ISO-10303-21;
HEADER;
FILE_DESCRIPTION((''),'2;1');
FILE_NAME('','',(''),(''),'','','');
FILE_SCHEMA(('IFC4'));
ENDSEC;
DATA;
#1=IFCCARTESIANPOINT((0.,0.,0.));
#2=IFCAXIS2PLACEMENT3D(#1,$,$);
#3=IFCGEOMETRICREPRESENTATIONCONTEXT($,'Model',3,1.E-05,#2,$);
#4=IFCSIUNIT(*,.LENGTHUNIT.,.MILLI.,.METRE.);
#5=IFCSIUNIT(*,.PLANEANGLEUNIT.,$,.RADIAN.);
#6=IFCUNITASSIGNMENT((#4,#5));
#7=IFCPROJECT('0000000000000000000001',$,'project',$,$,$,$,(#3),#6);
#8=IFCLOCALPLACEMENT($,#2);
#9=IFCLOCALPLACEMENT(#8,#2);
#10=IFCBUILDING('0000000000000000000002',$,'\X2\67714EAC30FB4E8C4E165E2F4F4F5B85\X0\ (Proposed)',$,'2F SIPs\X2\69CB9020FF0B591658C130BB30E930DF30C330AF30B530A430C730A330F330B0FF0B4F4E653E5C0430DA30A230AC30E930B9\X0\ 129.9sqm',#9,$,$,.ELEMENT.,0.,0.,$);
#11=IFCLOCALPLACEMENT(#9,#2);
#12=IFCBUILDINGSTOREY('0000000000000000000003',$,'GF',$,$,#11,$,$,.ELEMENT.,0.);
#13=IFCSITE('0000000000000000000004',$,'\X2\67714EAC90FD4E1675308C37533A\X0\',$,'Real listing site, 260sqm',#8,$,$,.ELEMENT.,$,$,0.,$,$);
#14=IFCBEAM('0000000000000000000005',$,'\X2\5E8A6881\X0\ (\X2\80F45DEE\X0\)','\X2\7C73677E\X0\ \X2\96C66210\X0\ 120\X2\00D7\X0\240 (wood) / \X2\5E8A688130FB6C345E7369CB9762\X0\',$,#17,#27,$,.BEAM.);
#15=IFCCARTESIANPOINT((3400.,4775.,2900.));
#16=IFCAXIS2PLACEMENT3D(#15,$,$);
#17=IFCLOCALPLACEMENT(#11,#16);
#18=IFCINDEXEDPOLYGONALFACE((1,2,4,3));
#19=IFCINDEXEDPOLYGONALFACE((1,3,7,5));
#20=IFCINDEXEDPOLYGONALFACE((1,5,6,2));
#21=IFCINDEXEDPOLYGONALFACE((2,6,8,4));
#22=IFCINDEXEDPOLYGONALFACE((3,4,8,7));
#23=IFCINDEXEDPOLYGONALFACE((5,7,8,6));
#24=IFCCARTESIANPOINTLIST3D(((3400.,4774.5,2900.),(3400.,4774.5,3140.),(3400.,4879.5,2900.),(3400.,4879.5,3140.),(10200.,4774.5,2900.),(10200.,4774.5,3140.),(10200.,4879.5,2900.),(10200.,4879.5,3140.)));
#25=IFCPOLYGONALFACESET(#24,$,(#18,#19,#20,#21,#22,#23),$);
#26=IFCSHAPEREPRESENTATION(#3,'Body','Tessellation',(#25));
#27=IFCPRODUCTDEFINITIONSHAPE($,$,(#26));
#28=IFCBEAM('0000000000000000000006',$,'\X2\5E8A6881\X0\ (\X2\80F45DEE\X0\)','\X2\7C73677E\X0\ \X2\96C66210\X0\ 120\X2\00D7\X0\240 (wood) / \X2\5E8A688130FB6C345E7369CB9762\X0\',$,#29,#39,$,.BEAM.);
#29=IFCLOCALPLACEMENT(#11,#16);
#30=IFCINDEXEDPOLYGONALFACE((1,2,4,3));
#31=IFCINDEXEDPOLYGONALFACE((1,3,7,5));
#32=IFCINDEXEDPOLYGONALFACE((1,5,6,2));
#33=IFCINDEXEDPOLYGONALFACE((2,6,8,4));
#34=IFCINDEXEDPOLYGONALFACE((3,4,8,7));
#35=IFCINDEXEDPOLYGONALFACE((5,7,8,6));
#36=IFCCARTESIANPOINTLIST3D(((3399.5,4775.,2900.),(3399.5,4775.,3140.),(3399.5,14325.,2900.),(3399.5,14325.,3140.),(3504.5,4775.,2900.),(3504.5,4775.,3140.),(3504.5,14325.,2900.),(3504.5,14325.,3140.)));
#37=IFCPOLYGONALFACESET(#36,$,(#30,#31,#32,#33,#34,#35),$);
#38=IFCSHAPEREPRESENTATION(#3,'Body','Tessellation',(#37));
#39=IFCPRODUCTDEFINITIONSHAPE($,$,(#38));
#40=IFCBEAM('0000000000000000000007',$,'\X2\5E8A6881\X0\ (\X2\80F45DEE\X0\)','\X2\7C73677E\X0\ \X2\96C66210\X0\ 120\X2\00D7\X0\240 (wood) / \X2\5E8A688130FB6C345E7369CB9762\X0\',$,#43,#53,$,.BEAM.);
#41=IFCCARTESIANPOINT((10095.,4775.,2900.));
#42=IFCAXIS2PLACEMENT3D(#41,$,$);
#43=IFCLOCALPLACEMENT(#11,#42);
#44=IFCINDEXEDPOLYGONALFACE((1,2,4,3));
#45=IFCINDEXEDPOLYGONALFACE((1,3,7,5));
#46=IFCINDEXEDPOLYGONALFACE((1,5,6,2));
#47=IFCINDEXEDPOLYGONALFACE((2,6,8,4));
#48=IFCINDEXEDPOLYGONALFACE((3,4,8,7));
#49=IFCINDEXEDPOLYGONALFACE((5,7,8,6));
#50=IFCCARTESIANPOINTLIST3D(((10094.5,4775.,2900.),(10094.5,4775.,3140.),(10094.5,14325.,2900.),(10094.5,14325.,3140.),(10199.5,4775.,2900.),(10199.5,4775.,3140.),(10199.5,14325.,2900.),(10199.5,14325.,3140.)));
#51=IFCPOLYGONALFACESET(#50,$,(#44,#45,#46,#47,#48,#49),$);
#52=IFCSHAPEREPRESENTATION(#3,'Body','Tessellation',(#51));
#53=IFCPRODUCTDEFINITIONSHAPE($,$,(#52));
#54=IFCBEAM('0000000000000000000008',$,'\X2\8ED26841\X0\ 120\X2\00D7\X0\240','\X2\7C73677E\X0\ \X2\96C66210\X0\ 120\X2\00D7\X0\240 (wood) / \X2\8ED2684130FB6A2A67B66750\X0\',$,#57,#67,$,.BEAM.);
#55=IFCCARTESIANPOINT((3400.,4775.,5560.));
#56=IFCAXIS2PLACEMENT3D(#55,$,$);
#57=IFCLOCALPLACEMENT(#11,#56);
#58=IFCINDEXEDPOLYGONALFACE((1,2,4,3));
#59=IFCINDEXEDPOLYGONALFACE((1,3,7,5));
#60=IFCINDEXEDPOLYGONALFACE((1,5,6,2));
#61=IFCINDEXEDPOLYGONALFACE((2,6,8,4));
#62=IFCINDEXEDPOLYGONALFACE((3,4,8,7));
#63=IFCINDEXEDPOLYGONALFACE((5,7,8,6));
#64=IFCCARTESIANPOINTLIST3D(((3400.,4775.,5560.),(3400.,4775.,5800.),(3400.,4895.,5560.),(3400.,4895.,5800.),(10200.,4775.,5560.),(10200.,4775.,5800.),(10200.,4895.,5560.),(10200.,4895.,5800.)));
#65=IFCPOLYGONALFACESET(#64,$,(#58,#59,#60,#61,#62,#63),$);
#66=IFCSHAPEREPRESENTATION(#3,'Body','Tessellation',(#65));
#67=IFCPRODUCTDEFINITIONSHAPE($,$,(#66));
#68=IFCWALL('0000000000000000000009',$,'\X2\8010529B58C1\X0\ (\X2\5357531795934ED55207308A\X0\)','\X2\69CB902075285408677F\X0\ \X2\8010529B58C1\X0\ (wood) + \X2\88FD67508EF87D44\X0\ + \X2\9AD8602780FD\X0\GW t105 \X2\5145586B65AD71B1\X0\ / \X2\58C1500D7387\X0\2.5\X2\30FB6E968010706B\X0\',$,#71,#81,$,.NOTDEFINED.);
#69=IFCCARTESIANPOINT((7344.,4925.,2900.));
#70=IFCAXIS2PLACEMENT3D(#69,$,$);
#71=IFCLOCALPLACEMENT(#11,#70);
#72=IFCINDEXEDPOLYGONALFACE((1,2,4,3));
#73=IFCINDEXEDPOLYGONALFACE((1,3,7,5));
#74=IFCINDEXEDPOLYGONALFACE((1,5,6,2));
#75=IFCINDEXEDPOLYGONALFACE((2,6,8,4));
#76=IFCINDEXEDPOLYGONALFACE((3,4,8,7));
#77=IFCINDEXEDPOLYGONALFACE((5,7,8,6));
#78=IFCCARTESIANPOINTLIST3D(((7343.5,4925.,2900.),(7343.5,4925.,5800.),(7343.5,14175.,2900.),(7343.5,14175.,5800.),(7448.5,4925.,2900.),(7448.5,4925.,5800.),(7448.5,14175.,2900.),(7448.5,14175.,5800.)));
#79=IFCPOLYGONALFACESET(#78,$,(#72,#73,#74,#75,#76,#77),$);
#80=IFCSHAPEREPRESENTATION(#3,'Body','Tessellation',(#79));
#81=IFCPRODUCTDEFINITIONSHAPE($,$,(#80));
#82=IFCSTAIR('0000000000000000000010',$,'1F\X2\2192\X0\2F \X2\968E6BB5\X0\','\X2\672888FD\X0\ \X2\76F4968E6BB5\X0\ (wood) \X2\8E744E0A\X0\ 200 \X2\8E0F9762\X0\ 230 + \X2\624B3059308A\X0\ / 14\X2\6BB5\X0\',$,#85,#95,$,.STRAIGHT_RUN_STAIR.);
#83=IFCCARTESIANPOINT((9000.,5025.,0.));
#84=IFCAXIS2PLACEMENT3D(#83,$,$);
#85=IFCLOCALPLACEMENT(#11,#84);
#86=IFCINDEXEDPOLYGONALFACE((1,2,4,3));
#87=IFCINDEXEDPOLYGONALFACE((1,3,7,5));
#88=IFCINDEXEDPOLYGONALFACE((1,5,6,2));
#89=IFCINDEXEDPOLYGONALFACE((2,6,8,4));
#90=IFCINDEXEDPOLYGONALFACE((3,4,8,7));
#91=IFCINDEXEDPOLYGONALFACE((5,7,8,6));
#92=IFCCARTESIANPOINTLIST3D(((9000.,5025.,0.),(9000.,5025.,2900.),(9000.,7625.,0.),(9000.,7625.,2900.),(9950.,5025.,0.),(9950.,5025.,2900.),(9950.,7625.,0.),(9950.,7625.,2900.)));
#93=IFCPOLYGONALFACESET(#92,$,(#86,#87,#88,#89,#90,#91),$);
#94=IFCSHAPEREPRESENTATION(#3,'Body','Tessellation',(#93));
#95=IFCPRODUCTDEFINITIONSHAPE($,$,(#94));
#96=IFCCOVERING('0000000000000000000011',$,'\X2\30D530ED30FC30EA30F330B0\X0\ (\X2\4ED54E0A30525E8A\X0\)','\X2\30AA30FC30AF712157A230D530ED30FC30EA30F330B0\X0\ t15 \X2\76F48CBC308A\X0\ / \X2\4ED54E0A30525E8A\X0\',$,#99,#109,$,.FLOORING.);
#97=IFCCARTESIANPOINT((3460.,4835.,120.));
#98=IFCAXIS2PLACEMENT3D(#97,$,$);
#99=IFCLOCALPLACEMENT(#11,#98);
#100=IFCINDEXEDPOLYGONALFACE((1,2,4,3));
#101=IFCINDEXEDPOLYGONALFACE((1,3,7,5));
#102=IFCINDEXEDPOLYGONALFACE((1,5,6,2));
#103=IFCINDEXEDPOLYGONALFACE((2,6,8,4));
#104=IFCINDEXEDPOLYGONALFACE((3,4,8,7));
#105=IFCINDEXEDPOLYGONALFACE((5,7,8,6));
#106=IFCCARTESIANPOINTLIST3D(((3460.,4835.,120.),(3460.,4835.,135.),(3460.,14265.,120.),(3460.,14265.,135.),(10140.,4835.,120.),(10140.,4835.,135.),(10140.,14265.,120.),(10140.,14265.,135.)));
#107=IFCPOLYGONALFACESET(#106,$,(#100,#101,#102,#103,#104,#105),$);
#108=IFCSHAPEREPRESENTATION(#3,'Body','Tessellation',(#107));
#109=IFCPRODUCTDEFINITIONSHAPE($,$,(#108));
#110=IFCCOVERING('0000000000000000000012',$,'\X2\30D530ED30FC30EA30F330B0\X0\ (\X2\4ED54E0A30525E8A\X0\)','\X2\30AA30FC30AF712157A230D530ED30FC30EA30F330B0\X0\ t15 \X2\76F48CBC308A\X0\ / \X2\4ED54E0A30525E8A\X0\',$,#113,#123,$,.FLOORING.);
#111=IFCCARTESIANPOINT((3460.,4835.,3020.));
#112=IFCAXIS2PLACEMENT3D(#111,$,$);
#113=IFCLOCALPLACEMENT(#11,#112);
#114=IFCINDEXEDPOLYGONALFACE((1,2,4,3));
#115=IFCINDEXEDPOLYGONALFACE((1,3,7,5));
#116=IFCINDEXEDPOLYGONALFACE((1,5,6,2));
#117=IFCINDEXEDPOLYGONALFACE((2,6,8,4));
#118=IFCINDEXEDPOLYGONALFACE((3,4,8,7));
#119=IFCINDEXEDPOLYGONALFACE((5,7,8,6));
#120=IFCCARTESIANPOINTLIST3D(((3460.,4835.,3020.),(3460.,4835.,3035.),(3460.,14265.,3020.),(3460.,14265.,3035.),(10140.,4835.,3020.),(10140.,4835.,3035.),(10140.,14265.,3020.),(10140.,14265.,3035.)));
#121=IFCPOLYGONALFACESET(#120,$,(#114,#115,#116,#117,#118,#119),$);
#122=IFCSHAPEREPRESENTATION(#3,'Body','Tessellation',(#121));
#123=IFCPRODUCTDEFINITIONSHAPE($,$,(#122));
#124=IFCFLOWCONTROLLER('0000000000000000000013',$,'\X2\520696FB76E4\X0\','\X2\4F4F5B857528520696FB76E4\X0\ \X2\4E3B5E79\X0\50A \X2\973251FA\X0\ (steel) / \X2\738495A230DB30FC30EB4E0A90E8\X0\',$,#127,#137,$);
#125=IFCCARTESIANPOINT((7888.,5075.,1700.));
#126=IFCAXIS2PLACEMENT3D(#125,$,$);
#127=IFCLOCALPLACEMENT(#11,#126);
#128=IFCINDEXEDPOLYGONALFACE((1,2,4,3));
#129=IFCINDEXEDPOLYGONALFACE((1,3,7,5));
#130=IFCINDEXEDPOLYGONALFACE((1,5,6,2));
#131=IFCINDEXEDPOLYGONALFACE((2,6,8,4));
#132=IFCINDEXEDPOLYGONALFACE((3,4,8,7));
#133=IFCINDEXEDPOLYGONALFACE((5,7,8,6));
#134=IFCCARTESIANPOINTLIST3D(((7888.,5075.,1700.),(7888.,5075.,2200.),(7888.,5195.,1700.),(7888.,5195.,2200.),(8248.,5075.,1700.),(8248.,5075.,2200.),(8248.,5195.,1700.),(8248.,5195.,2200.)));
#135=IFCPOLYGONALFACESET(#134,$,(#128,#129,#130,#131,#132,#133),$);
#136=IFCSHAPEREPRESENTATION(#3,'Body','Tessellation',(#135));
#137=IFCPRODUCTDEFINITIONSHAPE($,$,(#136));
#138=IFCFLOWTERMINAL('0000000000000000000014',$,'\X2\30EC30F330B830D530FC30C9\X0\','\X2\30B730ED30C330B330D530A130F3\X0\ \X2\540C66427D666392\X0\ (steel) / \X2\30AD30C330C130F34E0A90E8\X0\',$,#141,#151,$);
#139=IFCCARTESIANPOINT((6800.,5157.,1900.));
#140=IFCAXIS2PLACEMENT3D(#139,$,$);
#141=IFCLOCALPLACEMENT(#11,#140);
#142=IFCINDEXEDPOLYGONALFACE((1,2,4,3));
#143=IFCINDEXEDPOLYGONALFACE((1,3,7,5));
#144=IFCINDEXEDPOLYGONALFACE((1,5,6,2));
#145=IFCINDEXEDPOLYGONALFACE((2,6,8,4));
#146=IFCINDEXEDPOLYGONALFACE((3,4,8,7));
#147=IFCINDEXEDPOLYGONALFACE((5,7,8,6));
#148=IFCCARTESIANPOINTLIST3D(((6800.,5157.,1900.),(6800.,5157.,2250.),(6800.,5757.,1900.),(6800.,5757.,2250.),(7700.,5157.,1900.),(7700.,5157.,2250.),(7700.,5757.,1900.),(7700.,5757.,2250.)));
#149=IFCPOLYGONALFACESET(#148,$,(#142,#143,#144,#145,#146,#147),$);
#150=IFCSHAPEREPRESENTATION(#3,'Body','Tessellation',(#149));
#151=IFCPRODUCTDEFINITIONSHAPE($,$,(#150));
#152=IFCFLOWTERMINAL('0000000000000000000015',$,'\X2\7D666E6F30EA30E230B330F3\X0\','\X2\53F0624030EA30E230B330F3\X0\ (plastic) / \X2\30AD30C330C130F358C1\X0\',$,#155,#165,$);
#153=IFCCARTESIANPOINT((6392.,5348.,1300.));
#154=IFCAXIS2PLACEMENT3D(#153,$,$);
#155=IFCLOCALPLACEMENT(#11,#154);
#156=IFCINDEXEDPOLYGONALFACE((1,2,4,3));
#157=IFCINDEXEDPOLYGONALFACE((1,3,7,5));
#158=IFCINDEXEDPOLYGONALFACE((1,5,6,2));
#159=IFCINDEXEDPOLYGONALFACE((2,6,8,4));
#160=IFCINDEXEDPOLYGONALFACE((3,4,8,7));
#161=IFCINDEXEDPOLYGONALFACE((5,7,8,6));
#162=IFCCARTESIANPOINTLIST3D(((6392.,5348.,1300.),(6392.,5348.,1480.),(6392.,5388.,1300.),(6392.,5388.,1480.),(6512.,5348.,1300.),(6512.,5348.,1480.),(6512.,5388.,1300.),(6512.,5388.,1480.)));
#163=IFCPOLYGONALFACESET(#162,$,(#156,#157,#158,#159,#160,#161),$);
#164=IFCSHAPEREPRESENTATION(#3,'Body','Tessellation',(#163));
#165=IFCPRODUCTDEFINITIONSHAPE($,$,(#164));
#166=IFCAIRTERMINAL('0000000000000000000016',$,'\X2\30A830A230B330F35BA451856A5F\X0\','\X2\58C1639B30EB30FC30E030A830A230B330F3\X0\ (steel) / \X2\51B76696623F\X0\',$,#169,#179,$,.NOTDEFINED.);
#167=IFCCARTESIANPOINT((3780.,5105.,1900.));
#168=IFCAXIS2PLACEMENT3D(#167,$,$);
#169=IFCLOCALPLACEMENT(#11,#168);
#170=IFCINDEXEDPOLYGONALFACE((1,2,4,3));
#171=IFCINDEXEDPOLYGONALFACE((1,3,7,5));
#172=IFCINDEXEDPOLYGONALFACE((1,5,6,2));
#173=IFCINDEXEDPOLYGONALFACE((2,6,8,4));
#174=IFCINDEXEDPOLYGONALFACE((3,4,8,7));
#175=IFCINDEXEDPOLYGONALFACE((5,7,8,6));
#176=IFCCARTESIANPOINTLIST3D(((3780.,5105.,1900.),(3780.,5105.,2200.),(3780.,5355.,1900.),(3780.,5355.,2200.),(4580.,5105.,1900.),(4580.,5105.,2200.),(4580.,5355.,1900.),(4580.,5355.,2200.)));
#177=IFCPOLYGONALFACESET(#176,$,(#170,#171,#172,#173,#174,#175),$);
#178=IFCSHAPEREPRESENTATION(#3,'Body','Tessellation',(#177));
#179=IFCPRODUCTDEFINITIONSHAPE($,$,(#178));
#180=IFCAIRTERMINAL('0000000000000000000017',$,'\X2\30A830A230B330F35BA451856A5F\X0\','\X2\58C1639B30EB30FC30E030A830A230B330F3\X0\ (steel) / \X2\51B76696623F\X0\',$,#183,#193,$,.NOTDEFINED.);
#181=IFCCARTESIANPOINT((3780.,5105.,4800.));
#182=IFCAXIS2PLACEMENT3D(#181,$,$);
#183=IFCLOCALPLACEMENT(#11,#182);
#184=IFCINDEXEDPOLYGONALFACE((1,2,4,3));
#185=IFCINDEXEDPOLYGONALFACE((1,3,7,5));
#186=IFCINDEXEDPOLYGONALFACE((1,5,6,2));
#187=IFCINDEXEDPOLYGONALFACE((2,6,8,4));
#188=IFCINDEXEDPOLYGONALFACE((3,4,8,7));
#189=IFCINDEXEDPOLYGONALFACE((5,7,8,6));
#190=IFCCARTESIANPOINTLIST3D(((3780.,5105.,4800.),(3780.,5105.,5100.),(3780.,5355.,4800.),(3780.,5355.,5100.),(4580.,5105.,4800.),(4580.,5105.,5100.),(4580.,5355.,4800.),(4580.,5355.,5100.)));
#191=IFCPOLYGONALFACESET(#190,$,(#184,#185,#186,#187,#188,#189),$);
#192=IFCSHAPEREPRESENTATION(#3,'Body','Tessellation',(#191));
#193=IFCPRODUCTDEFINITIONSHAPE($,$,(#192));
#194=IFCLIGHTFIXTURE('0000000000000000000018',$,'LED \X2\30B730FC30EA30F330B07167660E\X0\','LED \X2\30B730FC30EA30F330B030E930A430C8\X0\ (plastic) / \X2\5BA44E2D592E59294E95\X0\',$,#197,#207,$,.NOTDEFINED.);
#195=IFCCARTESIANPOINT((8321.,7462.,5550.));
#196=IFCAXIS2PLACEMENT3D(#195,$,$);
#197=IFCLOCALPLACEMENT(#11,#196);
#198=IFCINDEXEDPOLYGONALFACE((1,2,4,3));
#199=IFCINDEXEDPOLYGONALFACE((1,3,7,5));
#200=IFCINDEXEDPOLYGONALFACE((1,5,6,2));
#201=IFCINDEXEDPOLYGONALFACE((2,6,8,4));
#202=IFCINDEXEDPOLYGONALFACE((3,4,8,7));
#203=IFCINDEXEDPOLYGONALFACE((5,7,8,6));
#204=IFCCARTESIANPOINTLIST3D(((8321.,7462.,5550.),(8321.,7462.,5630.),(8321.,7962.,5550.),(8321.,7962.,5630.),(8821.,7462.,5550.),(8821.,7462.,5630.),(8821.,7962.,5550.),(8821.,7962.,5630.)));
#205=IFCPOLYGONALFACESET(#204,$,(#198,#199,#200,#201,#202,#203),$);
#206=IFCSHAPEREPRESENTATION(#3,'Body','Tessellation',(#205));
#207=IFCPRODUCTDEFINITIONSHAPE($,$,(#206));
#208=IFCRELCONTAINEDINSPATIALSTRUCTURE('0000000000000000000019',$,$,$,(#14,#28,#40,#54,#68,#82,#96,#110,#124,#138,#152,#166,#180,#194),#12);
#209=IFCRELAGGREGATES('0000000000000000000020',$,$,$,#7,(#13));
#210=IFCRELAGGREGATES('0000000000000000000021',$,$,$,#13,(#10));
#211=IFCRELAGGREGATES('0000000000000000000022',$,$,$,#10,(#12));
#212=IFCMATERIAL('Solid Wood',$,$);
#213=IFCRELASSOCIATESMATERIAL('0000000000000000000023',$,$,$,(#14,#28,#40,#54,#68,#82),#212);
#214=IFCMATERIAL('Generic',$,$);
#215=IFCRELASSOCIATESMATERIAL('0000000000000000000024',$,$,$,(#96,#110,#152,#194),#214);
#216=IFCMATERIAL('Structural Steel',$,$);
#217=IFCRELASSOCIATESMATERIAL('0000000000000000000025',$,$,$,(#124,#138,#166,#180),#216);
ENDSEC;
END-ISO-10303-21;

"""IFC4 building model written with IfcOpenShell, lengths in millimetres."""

from ifc_helpers import new_model, si_unit, frame, frame_2d, origin, place, context, project, spatial, rectangle, extrude, material, element, save


model = new_model("IFC4")

# Units and contexts
model_context = context("Model", 3, precision=1e-05, world=origin())
ifc_project = project(units=[si_unit("LENGTHUNIT", "METRE", prefix="MILLI"), si_unit("PLANEANGLEUNIT", "RADIAN")], contexts=[model_context])

# Site, building, storey
site_placement = place(None, origin())
site = spatial("IfcSite", under=ifc_project, at=site_placement, Name="東京都世田谷区", ObjectType="Real listing site, 260sqm", CompositionType="ELEMENT", RefElevation=0.0)
building_placement = place(site_placement, origin())
building = spatial("IfcBuilding", under=site, at=building_placement, Name="東京・二世帯住宅 (Proposed)", ObjectType="2F SIPs構造＋外壁セラミックサイディング＋低放射ペアガラス 129.9sqm", CompositionType="ELEMENT", ElevationOfRefHeight=0.0, ElevationOfTerrain=0.0)
storey_placement = place(building_placement, origin())
storey = spatial("IfcBuildingStorey", under=building, at=storey_placement, Name="GF", CompositionType="ELEMENT", Elevation=0.0)

# Shared definitions
ifc_material_1 = material(Name="Solid Wood")

# Beams
beam_1_placement = place(storey_placement, frame((3400.0, 4775.0, 2900.0)))
element("IfcBeam", 1, at=beam_1_placement, inside=storey, material=ifc_material_1, Name="床梁 (胴差)", Description="米松 集成 120×240 (wood) / 床梁・水平構面", PredefinedType="BEAM", context=model_context, shape_type="SweptSolid", body=[
    extrude(rectangle(XDim=6800.0, YDim=105.0, at=frame_2d((3400.0, 52.0))), frame((3400.0, 4775.0, 2900.0)), (0.0, 0.0, 1.0), 240.0),
])
beam_2_placement = place(storey_placement, frame((3400.0, 4775.0, 2900.0)))
element("IfcBeam", 2, at=beam_2_placement, inside=storey, material=ifc_material_1, Name="床梁 (胴差)", Description="米松 集成 120×240 (wood) / 床梁・水平構面", PredefinedType="BEAM", context=model_context, shape_type="SweptSolid", body=[
    extrude(rectangle(XDim=105.0, YDim=9550.0, at=frame_2d((52.0, 4775.0))), frame((3400.0, 4775.0, 2900.0)), (0.0, 0.0, 1.0), 240.0),
])
beam_3_placement = place(storey_placement, frame((10095.0, 4775.0, 2900.0)))
element("IfcBeam", 3, at=beam_3_placement, inside=storey, material=ifc_material_1, Name="床梁 (胴差)", Description="米松 集成 120×240 (wood) / 床梁・水平構面", PredefinedType="BEAM", context=model_context, shape_type="SweptSolid", body=[
    extrude(rectangle(XDim=105.0, YDim=9550.0, at=frame_2d((52.0, 4775.0))), frame((10095.0, 4775.0, 2900.0)), (0.0, 0.0, 1.0), 240.0),
])
beam_4_placement = place(storey_placement, frame((3400.0, 4775.0, 5560.0)))
element("IfcBeam", 4, at=beam_4_placement, inside=storey, material=ifc_material_1, Name="軒桁 120×240", Description="米松 集成 120×240 (wood) / 軒桁・横架材", PredefinedType="BEAM", context=model_context, shape_type="SweptSolid", body=[
    extrude(rectangle(XDim=6800.0, YDim=120.0, at=frame_2d((3400.0, 60.0))), frame((3400.0, 4775.0, 5560.0)), (0.0, 0.0, 1.0), 240.0),
])

# Wall
wall_1_placement = place(storey_placement, frame((7344.0, 4925.0, 2900.0)))
element("IfcWall", 5, at=wall_1_placement, inside=storey, material=ifc_material_1, Name="耐力壁 (南北間仕切り)", Description="構造用合板 耐力壁 (wood) + 製材軸組 + 高性能GW t105 充填断熱 / 壁倍率2.5・準耐火", PredefinedType="NOTDEFINED", context=model_context, shape_type="SweptSolid", body=[
    extrude(rectangle(XDim=105.0, YDim=9250.0, at=frame_2d((52.0, 4625.0))), frame((7344.0, 4925.0, 2900.0)), (0.0, 0.0, 1.0), 2900.0),
])

# Stair
stair_placement = place(storey_placement, frame((9000.0, 5025.0, 0.0)))
element("IfcStair", 6, at=stair_placement, inside=storey, material=ifc_material_1, Name="1F→2F 階段", Description="木製 直階段 (wood) 蹴上 200 踏面 230 + 手すり / 14段", PredefinedType="STRAIGHT_RUN_STAIR", context=model_context, shape_type="SweptSolid", body=[
    extrude(rectangle(XDim=950.0, YDim=2600.0, at=frame_2d((475.0, 1300.0))), frame((9000.0, 5025.0, 0.0)), (0.0, 0.0, 1.0), 2900.0),
])

# Coverings
ifc_material_2 = material(Name="Generic")
covering_1_placement = place(storey_placement, frame((3460.0, 4835.0, 120.0)))
element("IfcCovering", 7, at=covering_1_placement, inside=storey, material=ifc_material_2, Name="フローリング (仕上げ床)", Description="オーク無垢フローリング t15 直貼り / 仕上げ床", PredefinedType="FLOORING", context=model_context, shape_type="SweptSolid", body=[
    extrude(rectangle(XDim=6680.0, YDim=9430.0, at=frame_2d((3340.0, 4715.0))), frame((3460.0, 4835.0, 120.0)), (0.0, 0.0, 1.0), 15.0),
])
covering_2_placement = place(storey_placement, frame((3460.0, 4835.0, 3020.0)))
element("IfcCovering", 8, at=covering_2_placement, inside=storey, material=ifc_material_2, Name="フローリング (仕上げ床)", Description="オーク無垢フローリング t15 直貼り / 仕上げ床", PredefinedType="FLOORING", context=model_context, shape_type="SweptSolid", body=[
    extrude(rectangle(XDim=6680.0, YDim=9430.0, at=frame_2d((3340.0, 4715.0))), frame((3460.0, 4835.0, 3020.0)), (0.0, 0.0, 1.0), 15.0),
])

# Flow controller
ifc_material_3 = material(Name="Structural Steel")
flow_controller_placement = place(storey_placement, frame((7888.0, 5075.0, 1700.0)))
element("IfcFlowController", 9, at=flow_controller_placement, inside=storey, material=ifc_material_3, Name="分電盤", Description="住宅用分電盤 主幹50A 露出 (steel) / 玄関ホール上部", context=model_context, shape_type="SweptSolid", body=[
    extrude(rectangle(XDim=360.0, YDim=120.0, at=frame_2d((180.0, 60.0))), frame((7888.0, 5075.0, 1700.0)), (0.0, 0.0, 1.0), 500.0),
])

# Flow terminals
flow_terminal_1_placement = place(storey_placement, frame((6800.0, 5157.0, 1900.0)))
element("IfcFlowTerminal", 10, at=flow_terminal_1_placement, inside=storey, material=ifc_material_3, Name="レンジフード", Description="シロッコファン 同時給排 (steel) / キッチン上部", context=model_context, shape_type="SweptSolid", body=[
    extrude(rectangle(XDim=900.0, YDim=600.0, at=frame_2d((450.0, 300.0))), frame((6800.0, 5157.0, 1900.0)), (0.0, 0.0, 1.0), 350.0),
])
flow_terminal_2_placement = place(storey_placement, frame((6392.0, 5348.0, 1300.0)))
element("IfcFlowTerminal", 11, at=flow_terminal_2_placement, inside=storey, material=ifc_material_2, Name="給湯リモコン", Description="台所リモコン (plastic) / キッチン壁", context=model_context, shape_type="SweptSolid", body=[
    extrude(rectangle(XDim=120.0, YDim=40.0, at=frame_2d((60.0, 20.0))), frame((6392.0, 5348.0, 1300.0)), (0.0, 0.0, 1.0), 180.0),
])

# Air terminals
air_terminal_1_placement = place(storey_placement, frame((3780.0, 5105.0, 1900.0)))
element("IfcAirTerminal", 12, at=air_terminal_1_placement, inside=storey, material=ifc_material_3, Name="エアコン室内機", Description="壁掛ルームエアコン (steel) / 冷暖房", PredefinedType="NOTDEFINED", context=model_context, shape_type="SweptSolid", body=[
    extrude(rectangle(XDim=800.0, YDim=250.0, at=frame_2d((400.0, 125.0))), frame((3780.0, 5105.0, 1900.0)), (0.0, 0.0, 1.0), 300.0),
])
air_terminal_2_placement = place(storey_placement, frame((3780.0, 5105.0, 4800.0)))
element("IfcAirTerminal", 13, at=air_terminal_2_placement, inside=storey, material=ifc_material_3, Name="エアコン室内機", Description="壁掛ルームエアコン (steel) / 冷暖房", PredefinedType="NOTDEFINED", context=model_context, shape_type="SweptSolid", body=[
    extrude(rectangle(XDim=800.0, YDim=250.0, at=frame_2d((400.0, 125.0))), frame((3780.0, 5105.0, 4800.0)), (0.0, 0.0, 1.0), 300.0),
])

# Light fixture
light_fixture_placement = place(storey_placement, frame((8321.0, 7462.0, 5550.0)))
element("IfcLightFixture", 14, at=light_fixture_placement, inside=storey, material=ifc_material_2, Name="LED シーリング照明", Description="LED シーリングライト (plastic) / 室中央天井", PredefinedType="NOTDEFINED", context=model_context, shape_type="SweptSolid", body=[
    extrude(rectangle(XDim=500.0, YDim=500.0, at=frame_2d((250.0, 250.0))), frame((8321.0, 7462.0, 5550.0)), (0.0, 0.0, 1.0), 80.0),
])

save(model, "model.ifc")
